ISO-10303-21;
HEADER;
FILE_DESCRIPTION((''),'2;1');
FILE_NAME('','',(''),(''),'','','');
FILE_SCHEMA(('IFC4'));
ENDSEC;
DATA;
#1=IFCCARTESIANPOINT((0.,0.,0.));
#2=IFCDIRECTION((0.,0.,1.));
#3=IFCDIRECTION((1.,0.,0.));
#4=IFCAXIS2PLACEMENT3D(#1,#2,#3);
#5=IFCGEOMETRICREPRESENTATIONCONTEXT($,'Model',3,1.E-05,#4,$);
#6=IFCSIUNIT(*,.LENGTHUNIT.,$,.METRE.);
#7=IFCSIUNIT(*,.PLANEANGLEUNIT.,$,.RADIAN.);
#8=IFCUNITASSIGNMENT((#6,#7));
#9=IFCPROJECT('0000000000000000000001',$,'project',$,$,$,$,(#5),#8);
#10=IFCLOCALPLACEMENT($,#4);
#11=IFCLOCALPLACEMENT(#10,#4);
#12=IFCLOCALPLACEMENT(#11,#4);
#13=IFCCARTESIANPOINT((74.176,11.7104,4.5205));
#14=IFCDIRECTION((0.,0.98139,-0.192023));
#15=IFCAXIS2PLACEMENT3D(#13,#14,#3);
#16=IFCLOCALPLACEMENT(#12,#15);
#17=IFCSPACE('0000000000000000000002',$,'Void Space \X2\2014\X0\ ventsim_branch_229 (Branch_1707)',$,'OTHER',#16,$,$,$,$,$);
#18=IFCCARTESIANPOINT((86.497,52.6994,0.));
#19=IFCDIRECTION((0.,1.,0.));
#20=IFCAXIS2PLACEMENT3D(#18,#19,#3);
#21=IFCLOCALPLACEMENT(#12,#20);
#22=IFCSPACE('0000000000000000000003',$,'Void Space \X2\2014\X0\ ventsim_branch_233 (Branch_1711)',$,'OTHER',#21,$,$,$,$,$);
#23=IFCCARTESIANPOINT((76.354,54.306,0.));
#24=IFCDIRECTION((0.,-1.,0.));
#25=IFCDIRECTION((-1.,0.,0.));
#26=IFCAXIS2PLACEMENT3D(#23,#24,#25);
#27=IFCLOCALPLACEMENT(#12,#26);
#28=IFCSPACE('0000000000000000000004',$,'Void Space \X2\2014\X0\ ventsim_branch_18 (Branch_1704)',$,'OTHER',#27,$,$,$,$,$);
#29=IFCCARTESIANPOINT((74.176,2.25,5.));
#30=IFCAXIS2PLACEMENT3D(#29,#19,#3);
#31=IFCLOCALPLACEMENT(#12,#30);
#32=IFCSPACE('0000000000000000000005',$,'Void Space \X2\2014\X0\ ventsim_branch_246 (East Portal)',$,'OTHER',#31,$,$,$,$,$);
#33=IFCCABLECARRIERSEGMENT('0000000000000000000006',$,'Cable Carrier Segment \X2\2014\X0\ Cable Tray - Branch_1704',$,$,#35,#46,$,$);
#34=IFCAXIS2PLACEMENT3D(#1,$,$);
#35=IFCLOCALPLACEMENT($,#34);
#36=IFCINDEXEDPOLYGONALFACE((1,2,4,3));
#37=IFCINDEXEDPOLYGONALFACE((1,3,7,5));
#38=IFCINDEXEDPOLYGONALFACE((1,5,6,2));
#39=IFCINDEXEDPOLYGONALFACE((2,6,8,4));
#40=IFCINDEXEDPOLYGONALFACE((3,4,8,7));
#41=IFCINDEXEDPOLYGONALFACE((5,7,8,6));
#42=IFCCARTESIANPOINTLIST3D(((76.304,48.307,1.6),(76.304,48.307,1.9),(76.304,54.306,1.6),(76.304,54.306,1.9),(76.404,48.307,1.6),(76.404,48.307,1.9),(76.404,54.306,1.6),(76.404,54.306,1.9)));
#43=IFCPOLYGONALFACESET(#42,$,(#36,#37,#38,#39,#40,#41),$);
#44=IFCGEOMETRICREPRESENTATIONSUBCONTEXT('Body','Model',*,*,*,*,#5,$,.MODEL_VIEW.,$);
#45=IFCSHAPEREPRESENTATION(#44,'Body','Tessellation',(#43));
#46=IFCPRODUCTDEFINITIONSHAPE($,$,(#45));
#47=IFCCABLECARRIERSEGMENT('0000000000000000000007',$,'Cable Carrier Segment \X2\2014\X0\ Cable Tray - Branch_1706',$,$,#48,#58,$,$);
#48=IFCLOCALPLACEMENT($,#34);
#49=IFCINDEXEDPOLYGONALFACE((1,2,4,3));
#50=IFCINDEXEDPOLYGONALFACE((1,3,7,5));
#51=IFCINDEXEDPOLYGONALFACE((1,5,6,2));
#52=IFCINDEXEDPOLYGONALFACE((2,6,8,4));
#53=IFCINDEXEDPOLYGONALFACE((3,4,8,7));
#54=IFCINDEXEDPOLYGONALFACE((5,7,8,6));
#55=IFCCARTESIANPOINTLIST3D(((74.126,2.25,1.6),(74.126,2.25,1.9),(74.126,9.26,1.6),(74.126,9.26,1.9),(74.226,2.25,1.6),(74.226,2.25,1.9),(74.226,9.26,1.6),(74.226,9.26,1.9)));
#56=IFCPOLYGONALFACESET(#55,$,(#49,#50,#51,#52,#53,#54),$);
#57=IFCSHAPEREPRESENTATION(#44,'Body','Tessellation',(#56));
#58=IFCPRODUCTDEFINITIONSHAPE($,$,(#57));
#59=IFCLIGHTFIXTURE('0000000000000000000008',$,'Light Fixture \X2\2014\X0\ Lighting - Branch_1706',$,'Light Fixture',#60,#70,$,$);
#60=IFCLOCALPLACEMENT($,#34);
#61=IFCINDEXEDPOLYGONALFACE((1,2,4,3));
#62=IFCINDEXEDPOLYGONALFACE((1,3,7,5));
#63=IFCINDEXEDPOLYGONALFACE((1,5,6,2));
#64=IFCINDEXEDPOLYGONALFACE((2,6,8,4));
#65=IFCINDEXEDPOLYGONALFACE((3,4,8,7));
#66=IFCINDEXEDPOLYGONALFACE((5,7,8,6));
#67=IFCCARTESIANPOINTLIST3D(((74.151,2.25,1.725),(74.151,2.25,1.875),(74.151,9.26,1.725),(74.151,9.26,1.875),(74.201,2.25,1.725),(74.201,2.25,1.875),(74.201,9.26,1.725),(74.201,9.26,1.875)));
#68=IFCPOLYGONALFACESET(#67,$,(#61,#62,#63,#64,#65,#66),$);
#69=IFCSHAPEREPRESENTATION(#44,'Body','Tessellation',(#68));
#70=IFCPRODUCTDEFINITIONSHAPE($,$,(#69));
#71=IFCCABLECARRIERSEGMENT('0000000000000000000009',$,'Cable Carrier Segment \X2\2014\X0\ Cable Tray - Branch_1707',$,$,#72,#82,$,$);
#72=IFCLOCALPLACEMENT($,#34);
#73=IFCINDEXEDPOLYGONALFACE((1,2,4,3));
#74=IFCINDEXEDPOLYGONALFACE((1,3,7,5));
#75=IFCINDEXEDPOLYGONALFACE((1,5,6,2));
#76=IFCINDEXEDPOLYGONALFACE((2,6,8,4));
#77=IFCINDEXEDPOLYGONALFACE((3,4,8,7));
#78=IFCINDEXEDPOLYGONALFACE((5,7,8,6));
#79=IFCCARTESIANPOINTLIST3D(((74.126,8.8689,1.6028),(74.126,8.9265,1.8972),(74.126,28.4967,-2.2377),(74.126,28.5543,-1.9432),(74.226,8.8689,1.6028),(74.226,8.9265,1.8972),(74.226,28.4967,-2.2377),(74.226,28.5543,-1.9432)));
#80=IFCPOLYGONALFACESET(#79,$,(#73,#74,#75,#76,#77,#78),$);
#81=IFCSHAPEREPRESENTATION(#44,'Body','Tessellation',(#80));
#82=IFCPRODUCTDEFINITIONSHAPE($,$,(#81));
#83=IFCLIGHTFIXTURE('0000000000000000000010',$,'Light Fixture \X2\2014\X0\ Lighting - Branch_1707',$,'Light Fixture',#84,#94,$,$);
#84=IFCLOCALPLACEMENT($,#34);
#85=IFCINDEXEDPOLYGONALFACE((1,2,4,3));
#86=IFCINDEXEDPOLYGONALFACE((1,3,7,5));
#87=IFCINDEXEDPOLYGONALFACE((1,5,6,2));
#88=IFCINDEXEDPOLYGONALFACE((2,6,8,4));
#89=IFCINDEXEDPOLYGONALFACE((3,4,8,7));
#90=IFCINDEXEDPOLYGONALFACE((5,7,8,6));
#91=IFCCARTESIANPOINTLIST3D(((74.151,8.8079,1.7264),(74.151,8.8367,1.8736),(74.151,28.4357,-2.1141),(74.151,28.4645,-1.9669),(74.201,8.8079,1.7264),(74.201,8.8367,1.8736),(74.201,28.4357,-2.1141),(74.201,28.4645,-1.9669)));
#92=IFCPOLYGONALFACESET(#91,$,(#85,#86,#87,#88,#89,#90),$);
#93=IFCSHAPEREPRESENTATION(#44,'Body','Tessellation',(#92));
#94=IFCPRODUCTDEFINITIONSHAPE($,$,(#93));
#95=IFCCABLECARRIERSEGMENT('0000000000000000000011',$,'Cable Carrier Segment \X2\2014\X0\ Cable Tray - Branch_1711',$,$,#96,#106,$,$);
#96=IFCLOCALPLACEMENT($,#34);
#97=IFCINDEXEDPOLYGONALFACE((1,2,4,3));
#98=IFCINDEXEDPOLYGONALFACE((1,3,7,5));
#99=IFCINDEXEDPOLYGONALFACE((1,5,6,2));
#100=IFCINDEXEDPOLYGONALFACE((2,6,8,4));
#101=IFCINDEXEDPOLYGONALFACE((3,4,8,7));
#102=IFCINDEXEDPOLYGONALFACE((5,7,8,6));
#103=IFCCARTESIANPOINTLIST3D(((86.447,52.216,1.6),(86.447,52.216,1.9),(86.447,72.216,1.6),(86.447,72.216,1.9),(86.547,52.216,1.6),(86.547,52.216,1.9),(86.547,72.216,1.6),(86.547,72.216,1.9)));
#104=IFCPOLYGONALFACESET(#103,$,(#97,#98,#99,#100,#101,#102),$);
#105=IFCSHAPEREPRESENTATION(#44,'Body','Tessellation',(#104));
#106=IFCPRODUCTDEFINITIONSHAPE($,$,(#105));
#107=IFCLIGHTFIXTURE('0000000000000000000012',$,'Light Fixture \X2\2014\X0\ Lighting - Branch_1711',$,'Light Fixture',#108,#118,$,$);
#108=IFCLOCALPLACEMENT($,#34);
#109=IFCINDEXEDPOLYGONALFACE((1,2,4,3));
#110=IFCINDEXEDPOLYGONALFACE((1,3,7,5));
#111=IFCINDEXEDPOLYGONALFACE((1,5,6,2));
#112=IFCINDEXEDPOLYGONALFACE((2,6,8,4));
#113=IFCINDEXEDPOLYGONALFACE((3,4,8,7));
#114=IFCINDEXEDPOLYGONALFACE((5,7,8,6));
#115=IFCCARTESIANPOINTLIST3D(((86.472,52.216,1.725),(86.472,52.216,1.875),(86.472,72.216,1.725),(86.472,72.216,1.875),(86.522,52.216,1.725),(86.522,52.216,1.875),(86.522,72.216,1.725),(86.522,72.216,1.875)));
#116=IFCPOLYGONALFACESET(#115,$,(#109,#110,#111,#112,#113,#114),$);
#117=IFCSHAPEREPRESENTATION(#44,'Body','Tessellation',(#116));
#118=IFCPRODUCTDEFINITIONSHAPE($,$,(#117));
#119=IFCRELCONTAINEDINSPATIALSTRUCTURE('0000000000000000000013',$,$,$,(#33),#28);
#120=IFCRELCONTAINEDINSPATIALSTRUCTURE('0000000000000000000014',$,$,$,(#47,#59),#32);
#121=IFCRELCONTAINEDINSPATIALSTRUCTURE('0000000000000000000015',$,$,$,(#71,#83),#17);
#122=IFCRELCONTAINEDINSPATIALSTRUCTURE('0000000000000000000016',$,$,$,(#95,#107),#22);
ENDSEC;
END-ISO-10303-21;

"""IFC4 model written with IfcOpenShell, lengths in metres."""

from ifc_helpers import new_model, si_unit, frame, origin_with_axes, origin_2d_with_axis, place, context, subcontext, project, spatial, rectangle, extrude, element, save


model = new_model("IFC4")

# Units and contexts
model_context = context("Model", 3, precision=1e-05, world=origin_with_axes())
body_context = subcontext(model_context, "Body", "Model", "MODEL_VIEW")
ifc_project = project(units=[si_unit("LENGTHUNIT", "METRE"), si_unit("PLANEANGLEUNIT", "RADIAN")], contexts=[model_context])

# Shared definitions
placement_1 = place(None, origin_with_axes())
placement_2 = place(placement_1, origin_with_axes())
placement_3 = place(placement_2, origin_with_axes())

# Shared definitions
space_1_placement = place(placement_3, frame((74.176, 11.7104, 4.5205), z_axis=(0.0, 0.98139, -0.192023), x_axis=(1.0, 0.0, 0.0)))
space_1 = spatial("IfcSpace", at=space_1_placement, Name="Void Space — ventsim_branch_229 (Branch_1707)", ObjectType="OTHER")

# Shared definitions
space_2_placement = place(placement_3, frame((86.497, 52.6994, 0.0), z_axis=(0.0, 1.0, 0.0), x_axis=(1.0, 0.0, 0.0)))
space_2 = spatial("IfcSpace", at=space_2_placement, Name="Void Space — ventsim_branch_233 (Branch_1711)", ObjectType="OTHER")

# Shared definitions
space_3_placement = place(placement_3, frame((76.354, 54.306, 0.0), z_axis=(0.0, -1.0, 0.0), x_axis=(-1.0, 0.0, 0.0)))
space_3 = spatial("IfcSpace", at=space_3_placement, Name="Void Space — ventsim_branch_18 (Branch_1704)", ObjectType="OTHER")

# Cable carrier segment
cable_carrier_segment_1_placement = place(placement_3, frame((76.354, 54.306, 1.75), z_axis=(0.0, -1.0, 0.0), x_axis=(0.0, 0.0, 1.0)))
element("IfcCableCarrierSegment", 1, at=cable_carrier_segment_1_placement, inside=space_3, Name="Cable Carrier Segment — Cable Tray - Branch_1704", context=body_context, shape_type="SweptSolid", body=[
    extrude(rectangle(XDim=0.3, YDim=0.1, at=origin_2d_with_axis()), origin_with_axes(), (0.0, 0.0, 1.0), 5.999),
])

# Shared definitions
space_4_placement = place(placement_3, frame((74.176, 2.25, 5.0), z_axis=(0.0, 1.0, 0.0), x_axis=(1.0, 0.0, 0.0)))
space_4 = spatial("IfcSpace", at=space_4_placement, Name="Void Space — ventsim_branch_246 (East Portal)", ObjectType="OTHER")

# Cable carrier segment
cable_carrier_segment_2_placement = place(placement_3, frame((74.176, 2.25, 1.75), z_axis=(0.0, 1.0, 0.0), x_axis=(0.0, 0.0, 1.0)))
element("IfcCableCarrierSegment", 2, at=cable_carrier_segment_2_placement, inside=space_4, Name="Cable Carrier Segment — Cable Tray - Branch_1706", context=body_context, shape_type="SweptSolid", body=[
    extrude(rectangle(XDim=0.3, YDim=0.1, at=origin_2d_with_axis()), origin_with_axes(), (0.0, 0.0, 1.0), 7.01),
])

# Light fixture
light_fixture_1_placement = place(placement_3, frame((74.176, 2.25, 1.8), z_axis=(0.0, 1.0, 0.0), x_axis=(0.0, 0.0, 1.0)))
element("IfcLightFixture", 3, at=light_fixture_1_placement, inside=space_4, Name="Light Fixture — Lighting - Branch_1706", ObjectType="Light Fixture", context=body_context, shape_type="SweptSolid", body=[
    extrude(rectangle(XDim=0.15, YDim=0.05, at=origin_2d_with_axis()), origin_with_axes(), (0.0, 0.0, 1.0), 7.01),
])

# Cable carrier segment
cable_carrier_segment_3_placement = place(placement_3, frame((74.176, 8.8977, 1.75), z_axis=(0.0, 0.98139, -0.192023), x_axis=(0.0, 0.192023, 0.98139)))
element("IfcCableCarrierSegment", 4, at=cable_carrier_segment_3_placement, inside=space_1, Name="Cable Carrier Segment — Cable Tray - Branch_1707", context=body_context, shape_type="SweptSolid", body=[
    extrude(rectangle(XDim=0.3, YDim=0.1, at=origin_2d_with_axis()), origin_with_axes(), (0.0, 0.0, 1.0), 20.0),
])

# Light fixture
light_fixture_2_placement = place(placement_3, frame((74.176, 8.8223, 1.8), z_axis=(0.0, 0.98139, -0.192023), x_axis=(0.0, 0.192023, 0.98139)))
element("IfcLightFixture", 5, at=light_fixture_2_placement, inside=space_1, Name="Light Fixture — Lighting - Branch_1707", ObjectType="Light Fixture", context=body_context, shape_type="SweptSolid", body=[
    extrude(rectangle(XDim=0.15, YDim=0.05, at=origin_2d_with_axis()), origin_with_axes(), (0.0, 0.0, 1.0), 20.0),
])

# Cable carrier segment
cable_carrier_segment_4_placement = place(placement_3, frame((86.497, 52.216, 1.75), z_axis=(0.0, 1.0, 0.0), x_axis=(0.0, 0.0, 1.0)))
element("IfcCableCarrierSegment", 6, at=cable_carrier_segment_4_placement, inside=space_2, Name="Cable Carrier Segment — Cable Tray - Branch_1711", context=body_context, shape_type="SweptSolid", body=[
    extrude(rectangle(XDim=0.3, YDim=0.1, at=origin_2d_with_axis()), origin_with_axes(), (0.0, 0.0, 1.0), 20.0),
])

# Light fixture
light_fixture_3_placement = place(placement_3, frame((86.497, 52.216, 1.8), z_axis=(0.0, 1.0, 0.0), x_axis=(0.0, 0.0, 1.0)))
element("IfcLightFixture", 7, at=light_fixture_3_placement, inside=space_2, Name="Light Fixture — Lighting - Branch_1711", ObjectType="Light Fixture", context=body_context, shape_type="SweptSolid", body=[
    extrude(rectangle(XDim=0.15, YDim=0.05, at=origin_2d_with_axis()), origin_with_axes(), (0.0, 0.0, 1.0), 20.0),
])

save(model, "model.ifc")
